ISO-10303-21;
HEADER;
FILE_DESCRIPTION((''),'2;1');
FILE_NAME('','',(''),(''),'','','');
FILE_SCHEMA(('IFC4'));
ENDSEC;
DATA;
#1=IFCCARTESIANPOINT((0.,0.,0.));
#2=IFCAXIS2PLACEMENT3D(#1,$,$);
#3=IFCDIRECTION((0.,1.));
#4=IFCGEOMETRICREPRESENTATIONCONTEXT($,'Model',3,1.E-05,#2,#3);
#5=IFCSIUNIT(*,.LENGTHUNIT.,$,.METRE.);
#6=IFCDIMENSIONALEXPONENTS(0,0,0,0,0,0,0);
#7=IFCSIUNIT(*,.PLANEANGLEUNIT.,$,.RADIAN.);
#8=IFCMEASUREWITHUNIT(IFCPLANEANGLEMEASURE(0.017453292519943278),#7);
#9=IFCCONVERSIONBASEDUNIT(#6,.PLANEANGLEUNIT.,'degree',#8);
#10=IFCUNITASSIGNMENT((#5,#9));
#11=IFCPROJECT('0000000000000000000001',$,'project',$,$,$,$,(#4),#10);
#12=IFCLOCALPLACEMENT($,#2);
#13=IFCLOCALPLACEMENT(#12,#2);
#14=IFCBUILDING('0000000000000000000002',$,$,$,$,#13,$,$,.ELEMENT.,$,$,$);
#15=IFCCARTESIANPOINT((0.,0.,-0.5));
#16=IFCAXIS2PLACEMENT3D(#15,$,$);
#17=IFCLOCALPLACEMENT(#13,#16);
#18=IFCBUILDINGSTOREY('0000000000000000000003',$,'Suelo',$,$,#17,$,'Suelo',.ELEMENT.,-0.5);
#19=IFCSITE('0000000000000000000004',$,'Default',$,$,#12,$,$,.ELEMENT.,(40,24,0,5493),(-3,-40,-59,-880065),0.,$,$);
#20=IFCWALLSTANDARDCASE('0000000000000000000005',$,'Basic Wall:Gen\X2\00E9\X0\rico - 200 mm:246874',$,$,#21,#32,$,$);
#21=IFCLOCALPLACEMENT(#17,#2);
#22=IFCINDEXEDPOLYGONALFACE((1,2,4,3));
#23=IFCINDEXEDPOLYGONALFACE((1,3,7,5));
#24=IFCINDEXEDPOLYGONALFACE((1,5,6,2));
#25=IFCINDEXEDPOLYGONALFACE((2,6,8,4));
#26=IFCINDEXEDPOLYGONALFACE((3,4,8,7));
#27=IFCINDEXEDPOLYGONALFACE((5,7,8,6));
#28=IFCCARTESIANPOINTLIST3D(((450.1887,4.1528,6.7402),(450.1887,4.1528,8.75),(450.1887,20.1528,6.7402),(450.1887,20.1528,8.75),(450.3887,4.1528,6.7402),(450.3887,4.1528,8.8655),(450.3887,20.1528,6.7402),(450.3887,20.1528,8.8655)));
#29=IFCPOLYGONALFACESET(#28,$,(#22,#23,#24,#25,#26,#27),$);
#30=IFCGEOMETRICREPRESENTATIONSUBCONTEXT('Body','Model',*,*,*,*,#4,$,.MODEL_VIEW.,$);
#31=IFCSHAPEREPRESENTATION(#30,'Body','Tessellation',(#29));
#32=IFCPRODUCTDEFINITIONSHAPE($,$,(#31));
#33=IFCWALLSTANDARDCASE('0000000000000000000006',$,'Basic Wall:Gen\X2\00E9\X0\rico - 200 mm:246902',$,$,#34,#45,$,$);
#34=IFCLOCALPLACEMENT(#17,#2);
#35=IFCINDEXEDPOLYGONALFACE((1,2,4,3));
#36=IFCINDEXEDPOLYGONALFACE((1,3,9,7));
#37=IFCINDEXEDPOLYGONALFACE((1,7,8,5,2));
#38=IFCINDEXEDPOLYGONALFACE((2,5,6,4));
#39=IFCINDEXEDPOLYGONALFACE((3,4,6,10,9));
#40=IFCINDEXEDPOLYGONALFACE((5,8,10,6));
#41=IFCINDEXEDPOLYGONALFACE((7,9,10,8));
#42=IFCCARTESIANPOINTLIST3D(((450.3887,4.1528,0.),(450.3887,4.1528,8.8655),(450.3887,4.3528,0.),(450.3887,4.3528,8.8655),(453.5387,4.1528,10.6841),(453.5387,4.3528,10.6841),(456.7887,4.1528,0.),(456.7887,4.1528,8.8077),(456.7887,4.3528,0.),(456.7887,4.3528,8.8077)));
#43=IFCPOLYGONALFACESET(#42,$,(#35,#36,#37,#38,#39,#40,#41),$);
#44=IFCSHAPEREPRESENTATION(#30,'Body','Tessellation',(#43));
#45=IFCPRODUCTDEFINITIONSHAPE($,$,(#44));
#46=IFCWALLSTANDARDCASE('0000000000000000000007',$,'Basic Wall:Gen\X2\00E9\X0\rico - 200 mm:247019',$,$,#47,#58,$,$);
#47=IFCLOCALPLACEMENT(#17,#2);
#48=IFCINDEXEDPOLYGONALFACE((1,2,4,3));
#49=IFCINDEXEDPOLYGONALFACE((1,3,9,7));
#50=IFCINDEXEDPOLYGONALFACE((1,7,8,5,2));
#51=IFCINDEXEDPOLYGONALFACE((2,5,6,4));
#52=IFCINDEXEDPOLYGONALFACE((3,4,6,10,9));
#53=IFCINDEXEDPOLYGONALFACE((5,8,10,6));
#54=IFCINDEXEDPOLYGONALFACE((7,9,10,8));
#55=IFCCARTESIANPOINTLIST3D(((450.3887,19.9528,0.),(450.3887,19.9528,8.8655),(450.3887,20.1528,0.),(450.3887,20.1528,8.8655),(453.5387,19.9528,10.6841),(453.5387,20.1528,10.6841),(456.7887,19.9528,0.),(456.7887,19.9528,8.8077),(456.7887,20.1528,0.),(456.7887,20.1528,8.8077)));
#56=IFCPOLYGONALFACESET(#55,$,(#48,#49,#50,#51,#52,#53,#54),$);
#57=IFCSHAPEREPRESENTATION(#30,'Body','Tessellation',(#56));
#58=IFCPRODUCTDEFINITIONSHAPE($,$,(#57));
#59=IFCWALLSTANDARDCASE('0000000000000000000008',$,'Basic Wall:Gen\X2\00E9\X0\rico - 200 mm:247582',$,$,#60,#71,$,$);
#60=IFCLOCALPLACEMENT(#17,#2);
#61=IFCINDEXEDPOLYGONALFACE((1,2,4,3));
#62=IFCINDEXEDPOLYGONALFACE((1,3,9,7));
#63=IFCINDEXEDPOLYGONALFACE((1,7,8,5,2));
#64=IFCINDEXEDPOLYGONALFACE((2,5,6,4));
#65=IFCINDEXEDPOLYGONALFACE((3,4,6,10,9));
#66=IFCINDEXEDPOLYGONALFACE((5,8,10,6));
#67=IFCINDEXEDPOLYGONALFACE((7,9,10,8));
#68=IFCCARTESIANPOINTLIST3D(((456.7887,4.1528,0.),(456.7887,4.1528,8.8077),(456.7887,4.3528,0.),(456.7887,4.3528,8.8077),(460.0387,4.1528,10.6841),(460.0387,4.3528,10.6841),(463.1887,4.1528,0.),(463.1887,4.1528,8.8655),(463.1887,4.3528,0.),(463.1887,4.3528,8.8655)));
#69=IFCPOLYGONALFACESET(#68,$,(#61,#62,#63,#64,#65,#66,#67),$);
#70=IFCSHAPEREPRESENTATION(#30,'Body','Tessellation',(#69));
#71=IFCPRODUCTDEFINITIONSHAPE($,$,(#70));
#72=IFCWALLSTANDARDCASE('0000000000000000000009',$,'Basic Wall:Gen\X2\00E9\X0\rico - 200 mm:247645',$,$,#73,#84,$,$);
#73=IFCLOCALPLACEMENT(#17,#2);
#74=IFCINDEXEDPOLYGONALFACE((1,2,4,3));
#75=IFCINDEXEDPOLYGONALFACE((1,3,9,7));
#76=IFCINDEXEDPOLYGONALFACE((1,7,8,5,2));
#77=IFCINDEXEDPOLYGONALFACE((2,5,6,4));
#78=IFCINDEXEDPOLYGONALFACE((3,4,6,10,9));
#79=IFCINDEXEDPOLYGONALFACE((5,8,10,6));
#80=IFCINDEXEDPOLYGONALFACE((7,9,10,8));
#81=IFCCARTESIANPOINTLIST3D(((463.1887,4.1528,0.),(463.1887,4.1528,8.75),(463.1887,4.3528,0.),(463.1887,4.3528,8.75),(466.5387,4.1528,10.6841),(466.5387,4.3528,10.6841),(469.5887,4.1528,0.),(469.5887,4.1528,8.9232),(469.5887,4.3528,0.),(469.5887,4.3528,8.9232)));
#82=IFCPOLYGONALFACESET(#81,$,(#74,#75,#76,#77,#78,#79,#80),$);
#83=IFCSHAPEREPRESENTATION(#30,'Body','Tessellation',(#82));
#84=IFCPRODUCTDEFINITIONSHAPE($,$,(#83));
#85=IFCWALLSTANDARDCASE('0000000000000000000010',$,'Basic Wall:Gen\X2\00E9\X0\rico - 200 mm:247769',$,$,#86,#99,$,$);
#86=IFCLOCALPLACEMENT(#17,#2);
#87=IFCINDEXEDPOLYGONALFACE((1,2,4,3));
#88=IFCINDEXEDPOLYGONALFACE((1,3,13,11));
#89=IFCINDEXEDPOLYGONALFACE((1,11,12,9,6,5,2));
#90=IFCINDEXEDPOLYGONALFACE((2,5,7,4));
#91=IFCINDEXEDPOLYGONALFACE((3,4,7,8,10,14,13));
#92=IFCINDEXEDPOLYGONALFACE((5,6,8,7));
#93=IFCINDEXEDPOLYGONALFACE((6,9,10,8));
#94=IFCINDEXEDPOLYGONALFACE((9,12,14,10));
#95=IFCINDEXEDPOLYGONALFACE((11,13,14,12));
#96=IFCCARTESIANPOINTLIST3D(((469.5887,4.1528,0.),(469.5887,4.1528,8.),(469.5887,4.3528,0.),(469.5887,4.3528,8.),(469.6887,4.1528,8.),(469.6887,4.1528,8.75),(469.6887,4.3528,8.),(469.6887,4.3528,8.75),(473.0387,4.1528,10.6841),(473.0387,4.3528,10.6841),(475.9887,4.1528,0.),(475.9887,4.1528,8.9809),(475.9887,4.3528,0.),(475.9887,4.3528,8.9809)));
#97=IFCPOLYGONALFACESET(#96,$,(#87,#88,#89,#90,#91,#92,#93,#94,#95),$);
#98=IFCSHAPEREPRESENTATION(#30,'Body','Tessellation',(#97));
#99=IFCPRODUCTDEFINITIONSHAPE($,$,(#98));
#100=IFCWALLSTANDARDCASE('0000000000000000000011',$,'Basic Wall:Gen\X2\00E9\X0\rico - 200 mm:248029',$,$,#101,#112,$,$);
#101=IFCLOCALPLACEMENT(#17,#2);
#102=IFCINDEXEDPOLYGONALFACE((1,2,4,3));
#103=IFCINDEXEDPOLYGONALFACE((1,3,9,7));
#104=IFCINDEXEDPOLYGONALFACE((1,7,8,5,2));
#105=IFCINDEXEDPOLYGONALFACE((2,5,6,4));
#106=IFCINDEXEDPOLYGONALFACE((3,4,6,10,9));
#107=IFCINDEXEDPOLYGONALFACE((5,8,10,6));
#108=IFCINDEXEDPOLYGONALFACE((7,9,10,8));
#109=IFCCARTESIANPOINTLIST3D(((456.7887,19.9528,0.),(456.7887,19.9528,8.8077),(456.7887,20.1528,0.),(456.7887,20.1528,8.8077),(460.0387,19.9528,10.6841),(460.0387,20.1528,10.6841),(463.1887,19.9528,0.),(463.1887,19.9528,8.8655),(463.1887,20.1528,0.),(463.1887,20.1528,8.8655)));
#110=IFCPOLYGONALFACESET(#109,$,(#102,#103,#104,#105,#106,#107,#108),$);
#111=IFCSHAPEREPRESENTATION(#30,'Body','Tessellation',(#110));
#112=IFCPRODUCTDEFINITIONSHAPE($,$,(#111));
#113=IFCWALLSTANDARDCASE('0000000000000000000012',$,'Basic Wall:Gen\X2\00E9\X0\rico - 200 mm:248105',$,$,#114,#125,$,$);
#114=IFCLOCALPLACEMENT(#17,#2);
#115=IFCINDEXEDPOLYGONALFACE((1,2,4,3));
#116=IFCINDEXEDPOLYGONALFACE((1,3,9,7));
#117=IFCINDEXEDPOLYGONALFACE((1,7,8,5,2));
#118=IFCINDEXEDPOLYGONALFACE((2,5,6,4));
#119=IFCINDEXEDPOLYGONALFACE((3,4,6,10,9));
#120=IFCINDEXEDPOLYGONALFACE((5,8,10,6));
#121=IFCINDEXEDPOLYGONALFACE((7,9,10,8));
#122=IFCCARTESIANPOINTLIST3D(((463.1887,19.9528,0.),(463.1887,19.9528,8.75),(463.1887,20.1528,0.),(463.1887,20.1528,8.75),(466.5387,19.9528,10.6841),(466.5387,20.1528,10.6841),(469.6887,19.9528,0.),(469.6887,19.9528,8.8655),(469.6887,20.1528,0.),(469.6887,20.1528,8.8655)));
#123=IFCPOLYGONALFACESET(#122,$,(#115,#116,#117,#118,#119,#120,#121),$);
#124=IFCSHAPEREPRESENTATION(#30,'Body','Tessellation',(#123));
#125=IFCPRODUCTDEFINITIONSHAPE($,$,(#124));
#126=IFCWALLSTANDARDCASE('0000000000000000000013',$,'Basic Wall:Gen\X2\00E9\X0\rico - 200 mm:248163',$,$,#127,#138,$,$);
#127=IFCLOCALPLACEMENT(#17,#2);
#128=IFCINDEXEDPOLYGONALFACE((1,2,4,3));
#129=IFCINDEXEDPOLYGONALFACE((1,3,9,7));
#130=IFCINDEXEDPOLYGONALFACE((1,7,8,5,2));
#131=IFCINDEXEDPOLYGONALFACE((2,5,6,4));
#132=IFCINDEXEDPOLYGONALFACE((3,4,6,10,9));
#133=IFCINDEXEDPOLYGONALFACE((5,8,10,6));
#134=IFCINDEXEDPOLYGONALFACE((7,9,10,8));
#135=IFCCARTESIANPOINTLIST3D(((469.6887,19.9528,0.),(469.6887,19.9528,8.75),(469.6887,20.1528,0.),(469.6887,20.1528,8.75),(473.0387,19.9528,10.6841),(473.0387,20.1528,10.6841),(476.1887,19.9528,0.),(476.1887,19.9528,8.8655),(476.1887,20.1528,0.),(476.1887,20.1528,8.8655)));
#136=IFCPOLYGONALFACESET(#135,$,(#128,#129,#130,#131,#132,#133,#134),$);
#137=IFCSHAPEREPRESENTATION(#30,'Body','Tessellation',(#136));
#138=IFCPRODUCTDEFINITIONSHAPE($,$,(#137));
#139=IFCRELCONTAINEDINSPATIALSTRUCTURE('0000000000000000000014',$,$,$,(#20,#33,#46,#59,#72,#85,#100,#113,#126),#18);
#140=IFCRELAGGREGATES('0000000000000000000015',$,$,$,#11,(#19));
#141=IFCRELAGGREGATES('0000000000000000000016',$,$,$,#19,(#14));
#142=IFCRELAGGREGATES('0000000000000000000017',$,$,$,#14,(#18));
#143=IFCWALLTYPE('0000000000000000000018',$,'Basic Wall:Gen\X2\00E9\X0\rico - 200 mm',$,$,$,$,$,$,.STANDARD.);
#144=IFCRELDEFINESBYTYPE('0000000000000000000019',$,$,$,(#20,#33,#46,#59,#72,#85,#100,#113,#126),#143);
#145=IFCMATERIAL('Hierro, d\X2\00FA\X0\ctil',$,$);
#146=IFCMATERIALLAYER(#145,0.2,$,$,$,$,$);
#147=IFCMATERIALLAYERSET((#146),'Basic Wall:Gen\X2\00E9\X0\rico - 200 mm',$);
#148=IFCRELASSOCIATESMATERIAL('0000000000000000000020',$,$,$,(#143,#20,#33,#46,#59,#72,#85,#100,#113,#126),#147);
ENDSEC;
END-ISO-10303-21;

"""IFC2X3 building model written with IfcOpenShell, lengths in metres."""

from ifc_helpers import new_model, entity, si_unit, converted_unit, direction, frame, frame_2d, origin, place, context, subcontext, project, spatial, polyline, rectangle, extrude, clip, bounded_halfspace, material, layer, layer_set, layer_usage, type_object, element, save


model = new_model("IFC2X3")

# Units and contexts
model_context = context("Model", 3, precision=1e-05, world=origin(), true_north=direction((0.0, 1.0)))
body_context = subcontext(model_context, "Body", "Model", "MODEL_VIEW")
ifc_project = project(units=[si_unit("LENGTHUNIT", "METRE"), converted_unit("PLANEANGLEUNIT", "degree", entity("IfcPlaneAngleMeasure", 0.017453292519943278), si_unit("PLANEANGLEUNIT", "RADIAN"), dimensions=[0, 0, 0, 0, 0, 0, 0])], contexts=[model_context])

# Site, building, storey
site_placement = place(None, origin())
site = spatial("IfcSite", under=ifc_project, at=site_placement, Name="Default", CompositionType="ELEMENT", RefLatitude=(40, 24, 0, 5493), RefLongitude=(-3, -40, -59, -880065), RefElevation=0.0)
building_placement = place(site_placement, origin())
building = spatial("IfcBuilding", under=site, at=building_placement, CompositionType="ELEMENT")
storey_placement = place(building_placement, frame((0.0, 0.0, -0.5)))
storey = spatial("IfcBuildingStorey", under=building, at=storey_placement, Name="Suelo", LongName="Suelo", CompositionType="ELEMENT", Elevation=-0.5)

# Walls
ifc_material_1 = material(Name="Hierro, dúctil")
ifc_layer_1 = layer(ifc_material_1, 0.2)
ifc_layer_set_1 = layer_set([ifc_layer_1], Name="Basic Wall:Genérico - 200 mm")
ifc_layer_usage_1 = layer_usage(ifc_layer_set_1, "AXIS2", "NEGATIVE", 0.1)
wall_type = type_object("IfcWallType", Name="Basic Wall:Genérico - 200 mm", PredefinedType="STANDARD", material=ifc_layer_set_1)
wall_1_placement = place(storey_placement, frame((450.2887, 20.1528, 6.7402), z_axis=(0.0, 0.0, 1.0), x_axis=(0.0, -1.0, 0.0)))
element("IfcWallStandardCase", 1, at=wall_1_placement, inside=storey, type_object=wall_type, material=ifc_layer_usage_1, Name="Basic Wall:Genérico - 200 mm:246874", context=body_context, shape_type="Clipping", body=[
    clip(extrude(rectangle(XDim=16.0, YDim=0.2, at=frame_2d((8.0, 0.0), x_axis=(-1.0, 0.0))), origin(), (0.0, 0.0, 1.0), 2.1253), bounded_halfspace(frame((0.0, -0.1, 2.0098), z_axis=(0.0, -0.5, 0.866025), x_axis=(1.0, 0.0, 0.0)), False, frame((0.0, -0.1, 2.0098)), polyline([(0.0, 0.0), (16.0, 0.0), (16.0, 0.2), (15.8, 0.2), (0.2, 0.2), (0.0, 0.2), (0.0, 0.0)]))),
])
ifc_layer_usage_2 = layer_usage(ifc_layer_set_1, "AXIS2", "NEGATIVE", 0.1)
wall_2_placement = place(storey_placement, frame((450.3887, 4.2528, 0.0)))
element("IfcWallStandardCase", 2, at=wall_2_placement, inside=storey, type_object=wall_type, material=ifc_layer_usage_2, Name="Basic Wall:Genérico - 200 mm:246902", context=body_context, shape_type="Clipping", body=[
    clip(clip(extrude(rectangle(XDim=6.4, YDim=0.2, at=frame_2d((3.2, 0.0), x_axis=(-1.0, 0.0))), origin(), (0.0, 0.0, 1.0), 10.6841), bounded_halfspace(frame((3.15, -0.1, 10.6841), z_axis=(0.5, 0.0, 0.866025), x_axis=(0.0, 1.0, 0.0)), False, frame((3.15, -0.1, 10.6841)), polyline([(0.0, 0.0), (3.25, 0.0), (3.25, 0.2), (0.0, 0.2), (0.0, 0.0)]))), bounded_halfspace(frame((0.0, -0.1, 8.8655), z_axis=(-0.5, 0.0, 0.866025), x_axis=(0.0, -1.0, 0.0)), False, frame((0.0, -0.1, 8.8655)), polyline([(0.0, 0.0), (3.15, 0.0), (3.15, 0.2), (0.0, 0.2), (0.0, 0.0)]))),
])
ifc_layer_usage_3 = layer_usage(ifc_layer_set_1, "AXIS2", "NEGATIVE", 0.1)
wall_3_placement = place(storey_placement, frame((456.7887, 20.0528, 0.0), z_axis=(0.0, 0.0, 1.0), x_axis=(-1.0, 0.0, 0.0)))
element("IfcWallStandardCase", 3, at=wall_3_placement, inside=storey, type_object=wall_type, material=ifc_layer_usage_3, Name="Basic Wall:Genérico - 200 mm:247019", context=body_context, shape_type="Clipping", body=[
    clip(clip(extrude(rectangle(XDim=6.4, YDim=0.2, at=frame_2d((3.2, 0.0), x_axis=(-1.0, 0.0))), origin(), (0.0, 0.0, 1.0), 10.6841), bounded_halfspace(frame((0.0, -0.1, 8.8077), z_axis=(-0.5, 0.0, 0.866025), x_axis=(0.0, -1.0, 0.0)), False, frame((0.0, -0.1, 8.8077)), polyline([(0.0, 0.0), (3.25, 0.0), (3.25, 0.2), (0.0, 0.2), (0.0, 0.0)]))), bounded_halfspace(frame((3.25, -0.1, 10.6841), z_axis=(0.5, 0.0, 0.866025), x_axis=(0.0, 1.0, 0.0)), False, frame((3.25, -0.1, 10.6841)), polyline([(0.0, 0.0), (3.15, 0.0), (3.15, 0.2), (0.0, 0.2), (0.0, 0.0)]))),
])
ifc_layer_usage_4 = layer_usage(ifc_layer_set_1, "AXIS2", "NEGATIVE", 0.1)
wall_4_placement = place(storey_placement, frame((456.7887, 4.2528, 0.0)))
element("IfcWallStandardCase", 4, at=wall_4_placement, inside=storey, type_object=wall_type, material=ifc_layer_usage_4, Name="Basic Wall:Genérico - 200 mm:247582", context=body_context, shape_type="Clipping", body=[
    clip(clip(extrude(rectangle(XDim=6.4, YDim=0.2, at=frame_2d((3.2, 0.0), x_axis=(-1.0, 0.0))), origin(), (0.0, 0.0, 1.0), 10.6841), bounded_halfspace(frame((3.25, -0.1, 10.6841), z_axis=(0.5, 0.0, 0.866025), x_axis=(0.0, 1.0, 0.0)), False, frame((3.25, -0.1, 10.6841)), polyline([(0.0, 0.0), (3.15, 0.0), (3.15, 0.2), (0.0, 0.2), (0.0, 0.0)]))), bounded_halfspace(frame((0.0, -0.1, 8.8077), z_axis=(-0.5, 0.0, 0.866025), x_axis=(0.0, -1.0, 0.0)), False, frame((0.0, -0.1, 8.8077)), polyline([(0.0, 0.0), (3.25, 0.0), (3.25, 0.2), (0.0, 0.2), (0.0, 0.0)]))),
])
ifc_layer_usage_5 = layer_usage(ifc_layer_set_1, "AXIS2", "NEGATIVE", 0.1)
wall_5_placement = place(storey_placement, frame((463.1887, 4.2528, 0.0)))
element("IfcWallStandardCase", 5, at=wall_5_placement, inside=storey, type_object=wall_type, material=ifc_layer_usage_5, Name="Basic Wall:Genérico - 200 mm:247645", context=body_context, shape_type="Clipping", body=[
    clip(clip(extrude(rectangle(XDim=6.4, YDim=0.2, at=frame_2d((3.2, 0.0), x_axis=(-1.0, 0.0))), origin(), (0.0, 0.0, 1.0), 10.6841), bounded_halfspace(frame((3.35, -0.1, 10.6841), z_axis=(0.5, 0.0, 0.866025), x_axis=(0.0, 1.0, 0.0)), False, frame((3.35, -0.1, 10.6841)), polyline([(0.0, 0.0), (3.05, 0.0), (3.05, 0.2), (0.0, 0.2), (0.0, 0.0)]))), bounded_halfspace(frame((0.0, -0.1, 8.75), z_axis=(-0.5, 0.0, 0.866025), x_axis=(0.0, -1.0, 0.0)), False, frame((0.0, -0.1, 8.75)), polyline([(0.0, 0.0), (3.35, 0.0), (3.35, 0.2), (0.0, 0.2), (0.0, 0.0)]))),
])
ifc_layer_usage_6 = layer_usage(ifc_layer_set_1, "AXIS2", "NEGATIVE", 0.1)
wall_6_placement = place(storey_placement, frame((469.5887, 4.2528, 0.0)))
element("IfcWallStandardCase", 6, at=wall_6_placement, inside=storey, type_object=wall_type, material=ifc_layer_usage_6, Name="Basic Wall:Genérico - 200 mm:247769", context=body_context, shape_type="Clipping", body=[
    clip(clip(clip(extrude(rectangle(XDim=6.4, YDim=0.2, at=frame_2d((3.2, 0.0), x_axis=(-1.0, 0.0))), origin(), (0.0, 0.0, 1.0), 10.6841), bounded_halfspace(frame((3.45, -0.1, 10.6841), z_axis=(0.5, 0.0, 0.866025), x_axis=(0.0, 1.0, 0.0)), False, frame((3.45, -0.1, 10.6841)), polyline([(0.0, 0.0), (2.95, 0.0), (2.95, 0.2), (0.0, 0.2), (0.0, 0.0)]))), bounded_halfspace(frame((0.1, -0.1, 8.75), z_axis=(-0.5, 0.0, 0.866025), x_axis=(0.0, -1.0, 0.0)), False, frame((0.1, -0.1, 8.75)), polyline([(0.0, 0.0), (3.35, 0.0), (3.35, 0.2), (0.0, 0.2), (0.0, 0.0)]))), bounded_halfspace(frame((0.0, -0.1, 8.0), z_axis=(0.0, 0.0, 1.0), x_axis=(0.0, 1.0, 0.0)), False, frame((0.0, -0.1, 8.0)), polyline([(0.0, 0.0), (0.1, 0.0), (0.1, 0.2), (0.0, 0.2), (0.0, 0.0)]))),
])
ifc_layer_usage_7 = layer_usage(ifc_layer_set_1, "AXIS2", "NEGATIVE", 0.1)
wall_7_placement = place(storey_placement, frame((463.1887, 20.0528, 0.0), z_axis=(0.0, 0.0, 1.0), x_axis=(-1.0, 0.0, 0.0)))
element("IfcWallStandardCase", 7, at=wall_7_placement, inside=storey, type_object=wall_type, material=ifc_layer_usage_7, Name="Basic Wall:Genérico - 200 mm:248029", context=body_context, shape_type="Clipping", body=[
    clip(clip(extrude(rectangle(XDim=6.4, YDim=0.2, at=frame_2d((3.2, 0.0), x_axis=(-1.0, 0.0))), origin(), (0.0, 0.0, 1.0), 10.6841), bounded_halfspace(frame((0.0, -0.1, 8.8655), z_axis=(-0.5, 0.0, 0.866025), x_axis=(0.0, -1.0, 0.0)), False, frame((0.0, -0.1, 8.8655)), polyline([(0.0, 0.0), (3.15, 0.0), (3.15, 0.2), (0.0, 0.2), (0.0, 0.0)]))), bounded_halfspace(frame((3.15, -0.1, 10.6841), z_axis=(0.5, 0.0, 0.866025), x_axis=(0.0, 1.0, 0.0)), False, frame((3.15, -0.1, 10.6841)), polyline([(0.0, 0.0), (3.25, 0.0), (3.25, 0.2), (0.0, 0.2), (0.0, 0.0)]))),
])
ifc_layer_usage_8 = layer_usage(ifc_layer_set_1, "AXIS2", "NEGATIVE", 0.1)
wall_8_placement = place(storey_placement, frame((469.6887, 20.0528, 0.0), z_axis=(0.0, 0.0, 1.0), x_axis=(-1.0, 0.0, 0.0)))
element("IfcWallStandardCase", 8, at=wall_8_placement, inside=storey, type_object=wall_type, material=ifc_layer_usage_8, Name="Basic Wall:Genérico - 200 mm:248105", context=body_context, shape_type="Clipping", body=[
    clip(clip(extrude(rectangle(XDim=6.5, YDim=0.2, at=frame_2d((3.25, 0.0), x_axis=(-1.0, 0.0))), origin(), (0.0, 0.0, 1.0), 10.6841), bounded_halfspace(frame((0.0, -0.1, 8.8655), z_axis=(-0.5, 0.0, 0.866025), x_axis=(0.0, -1.0, 0.0)), False, frame((0.0, -0.1, 8.8655)), polyline([(0.0, 0.0), (3.15, 0.0), (3.15, 0.2), (0.0, 0.2), (0.0, 0.0)]))), bounded_halfspace(frame((3.15, -0.1, 10.6841), z_axis=(0.5, 0.0, 0.866025), x_axis=(0.0, 1.0, 0.0)), False, frame((3.15, -0.1, 10.6841)), polyline([(0.0, 0.0), (3.35, 0.0), (3.35, 0.2), (0.0, 0.2), (0.0, 0.0)]))),
])
ifc_layer_usage_9 = layer_usage(ifc_layer_set_1, "AXIS2", "NEGATIVE", 0.1)
wall_9_placement = place(storey_placement, frame((476.1887, 20.0528, 0.0), z_axis=(0.0, 0.0, 1.0), x_axis=(-1.0, 0.0, 0.0)))
element("IfcWallStandardCase", 9, at=wall_9_placement, inside=storey, type_object=wall_type, material=ifc_layer_usage_9, Name="Basic Wall:Genérico - 200 mm:248163", context=body_context, shape_type="Clipping", body=[
    clip(clip(extrude(rectangle(XDim=6.5, YDim=0.2, at=frame_2d((3.25, 0.0), x_axis=(-1.0, 0.0))), origin(), (0.0, 0.0, 1.0), 10.6841), bounded_halfspace(frame((0.0, -0.1, 8.8655), z_axis=(-0.5, 0.0, 0.866025), x_axis=(0.0, -1.0, 0.0)), False, frame((0.0, -0.1, 8.8655)), polyline([(0.0, 0.0), (3.15, 0.0), (3.15, 0.2), (0.0, 0.2), (0.0, 0.0)]))), bounded_halfspace(frame((3.15, -0.1, 10.6841), z_axis=(0.5, 0.0, 0.866025), x_axis=(0.0, 1.0, 0.0)), False, frame((3.15, -0.1, 10.6841)), polyline([(0.0, 0.0), (3.35, 0.0), (3.35, 0.2), (0.0, 0.2), (0.0, 0.0)]))),
])

save(model, "model.ifc")
